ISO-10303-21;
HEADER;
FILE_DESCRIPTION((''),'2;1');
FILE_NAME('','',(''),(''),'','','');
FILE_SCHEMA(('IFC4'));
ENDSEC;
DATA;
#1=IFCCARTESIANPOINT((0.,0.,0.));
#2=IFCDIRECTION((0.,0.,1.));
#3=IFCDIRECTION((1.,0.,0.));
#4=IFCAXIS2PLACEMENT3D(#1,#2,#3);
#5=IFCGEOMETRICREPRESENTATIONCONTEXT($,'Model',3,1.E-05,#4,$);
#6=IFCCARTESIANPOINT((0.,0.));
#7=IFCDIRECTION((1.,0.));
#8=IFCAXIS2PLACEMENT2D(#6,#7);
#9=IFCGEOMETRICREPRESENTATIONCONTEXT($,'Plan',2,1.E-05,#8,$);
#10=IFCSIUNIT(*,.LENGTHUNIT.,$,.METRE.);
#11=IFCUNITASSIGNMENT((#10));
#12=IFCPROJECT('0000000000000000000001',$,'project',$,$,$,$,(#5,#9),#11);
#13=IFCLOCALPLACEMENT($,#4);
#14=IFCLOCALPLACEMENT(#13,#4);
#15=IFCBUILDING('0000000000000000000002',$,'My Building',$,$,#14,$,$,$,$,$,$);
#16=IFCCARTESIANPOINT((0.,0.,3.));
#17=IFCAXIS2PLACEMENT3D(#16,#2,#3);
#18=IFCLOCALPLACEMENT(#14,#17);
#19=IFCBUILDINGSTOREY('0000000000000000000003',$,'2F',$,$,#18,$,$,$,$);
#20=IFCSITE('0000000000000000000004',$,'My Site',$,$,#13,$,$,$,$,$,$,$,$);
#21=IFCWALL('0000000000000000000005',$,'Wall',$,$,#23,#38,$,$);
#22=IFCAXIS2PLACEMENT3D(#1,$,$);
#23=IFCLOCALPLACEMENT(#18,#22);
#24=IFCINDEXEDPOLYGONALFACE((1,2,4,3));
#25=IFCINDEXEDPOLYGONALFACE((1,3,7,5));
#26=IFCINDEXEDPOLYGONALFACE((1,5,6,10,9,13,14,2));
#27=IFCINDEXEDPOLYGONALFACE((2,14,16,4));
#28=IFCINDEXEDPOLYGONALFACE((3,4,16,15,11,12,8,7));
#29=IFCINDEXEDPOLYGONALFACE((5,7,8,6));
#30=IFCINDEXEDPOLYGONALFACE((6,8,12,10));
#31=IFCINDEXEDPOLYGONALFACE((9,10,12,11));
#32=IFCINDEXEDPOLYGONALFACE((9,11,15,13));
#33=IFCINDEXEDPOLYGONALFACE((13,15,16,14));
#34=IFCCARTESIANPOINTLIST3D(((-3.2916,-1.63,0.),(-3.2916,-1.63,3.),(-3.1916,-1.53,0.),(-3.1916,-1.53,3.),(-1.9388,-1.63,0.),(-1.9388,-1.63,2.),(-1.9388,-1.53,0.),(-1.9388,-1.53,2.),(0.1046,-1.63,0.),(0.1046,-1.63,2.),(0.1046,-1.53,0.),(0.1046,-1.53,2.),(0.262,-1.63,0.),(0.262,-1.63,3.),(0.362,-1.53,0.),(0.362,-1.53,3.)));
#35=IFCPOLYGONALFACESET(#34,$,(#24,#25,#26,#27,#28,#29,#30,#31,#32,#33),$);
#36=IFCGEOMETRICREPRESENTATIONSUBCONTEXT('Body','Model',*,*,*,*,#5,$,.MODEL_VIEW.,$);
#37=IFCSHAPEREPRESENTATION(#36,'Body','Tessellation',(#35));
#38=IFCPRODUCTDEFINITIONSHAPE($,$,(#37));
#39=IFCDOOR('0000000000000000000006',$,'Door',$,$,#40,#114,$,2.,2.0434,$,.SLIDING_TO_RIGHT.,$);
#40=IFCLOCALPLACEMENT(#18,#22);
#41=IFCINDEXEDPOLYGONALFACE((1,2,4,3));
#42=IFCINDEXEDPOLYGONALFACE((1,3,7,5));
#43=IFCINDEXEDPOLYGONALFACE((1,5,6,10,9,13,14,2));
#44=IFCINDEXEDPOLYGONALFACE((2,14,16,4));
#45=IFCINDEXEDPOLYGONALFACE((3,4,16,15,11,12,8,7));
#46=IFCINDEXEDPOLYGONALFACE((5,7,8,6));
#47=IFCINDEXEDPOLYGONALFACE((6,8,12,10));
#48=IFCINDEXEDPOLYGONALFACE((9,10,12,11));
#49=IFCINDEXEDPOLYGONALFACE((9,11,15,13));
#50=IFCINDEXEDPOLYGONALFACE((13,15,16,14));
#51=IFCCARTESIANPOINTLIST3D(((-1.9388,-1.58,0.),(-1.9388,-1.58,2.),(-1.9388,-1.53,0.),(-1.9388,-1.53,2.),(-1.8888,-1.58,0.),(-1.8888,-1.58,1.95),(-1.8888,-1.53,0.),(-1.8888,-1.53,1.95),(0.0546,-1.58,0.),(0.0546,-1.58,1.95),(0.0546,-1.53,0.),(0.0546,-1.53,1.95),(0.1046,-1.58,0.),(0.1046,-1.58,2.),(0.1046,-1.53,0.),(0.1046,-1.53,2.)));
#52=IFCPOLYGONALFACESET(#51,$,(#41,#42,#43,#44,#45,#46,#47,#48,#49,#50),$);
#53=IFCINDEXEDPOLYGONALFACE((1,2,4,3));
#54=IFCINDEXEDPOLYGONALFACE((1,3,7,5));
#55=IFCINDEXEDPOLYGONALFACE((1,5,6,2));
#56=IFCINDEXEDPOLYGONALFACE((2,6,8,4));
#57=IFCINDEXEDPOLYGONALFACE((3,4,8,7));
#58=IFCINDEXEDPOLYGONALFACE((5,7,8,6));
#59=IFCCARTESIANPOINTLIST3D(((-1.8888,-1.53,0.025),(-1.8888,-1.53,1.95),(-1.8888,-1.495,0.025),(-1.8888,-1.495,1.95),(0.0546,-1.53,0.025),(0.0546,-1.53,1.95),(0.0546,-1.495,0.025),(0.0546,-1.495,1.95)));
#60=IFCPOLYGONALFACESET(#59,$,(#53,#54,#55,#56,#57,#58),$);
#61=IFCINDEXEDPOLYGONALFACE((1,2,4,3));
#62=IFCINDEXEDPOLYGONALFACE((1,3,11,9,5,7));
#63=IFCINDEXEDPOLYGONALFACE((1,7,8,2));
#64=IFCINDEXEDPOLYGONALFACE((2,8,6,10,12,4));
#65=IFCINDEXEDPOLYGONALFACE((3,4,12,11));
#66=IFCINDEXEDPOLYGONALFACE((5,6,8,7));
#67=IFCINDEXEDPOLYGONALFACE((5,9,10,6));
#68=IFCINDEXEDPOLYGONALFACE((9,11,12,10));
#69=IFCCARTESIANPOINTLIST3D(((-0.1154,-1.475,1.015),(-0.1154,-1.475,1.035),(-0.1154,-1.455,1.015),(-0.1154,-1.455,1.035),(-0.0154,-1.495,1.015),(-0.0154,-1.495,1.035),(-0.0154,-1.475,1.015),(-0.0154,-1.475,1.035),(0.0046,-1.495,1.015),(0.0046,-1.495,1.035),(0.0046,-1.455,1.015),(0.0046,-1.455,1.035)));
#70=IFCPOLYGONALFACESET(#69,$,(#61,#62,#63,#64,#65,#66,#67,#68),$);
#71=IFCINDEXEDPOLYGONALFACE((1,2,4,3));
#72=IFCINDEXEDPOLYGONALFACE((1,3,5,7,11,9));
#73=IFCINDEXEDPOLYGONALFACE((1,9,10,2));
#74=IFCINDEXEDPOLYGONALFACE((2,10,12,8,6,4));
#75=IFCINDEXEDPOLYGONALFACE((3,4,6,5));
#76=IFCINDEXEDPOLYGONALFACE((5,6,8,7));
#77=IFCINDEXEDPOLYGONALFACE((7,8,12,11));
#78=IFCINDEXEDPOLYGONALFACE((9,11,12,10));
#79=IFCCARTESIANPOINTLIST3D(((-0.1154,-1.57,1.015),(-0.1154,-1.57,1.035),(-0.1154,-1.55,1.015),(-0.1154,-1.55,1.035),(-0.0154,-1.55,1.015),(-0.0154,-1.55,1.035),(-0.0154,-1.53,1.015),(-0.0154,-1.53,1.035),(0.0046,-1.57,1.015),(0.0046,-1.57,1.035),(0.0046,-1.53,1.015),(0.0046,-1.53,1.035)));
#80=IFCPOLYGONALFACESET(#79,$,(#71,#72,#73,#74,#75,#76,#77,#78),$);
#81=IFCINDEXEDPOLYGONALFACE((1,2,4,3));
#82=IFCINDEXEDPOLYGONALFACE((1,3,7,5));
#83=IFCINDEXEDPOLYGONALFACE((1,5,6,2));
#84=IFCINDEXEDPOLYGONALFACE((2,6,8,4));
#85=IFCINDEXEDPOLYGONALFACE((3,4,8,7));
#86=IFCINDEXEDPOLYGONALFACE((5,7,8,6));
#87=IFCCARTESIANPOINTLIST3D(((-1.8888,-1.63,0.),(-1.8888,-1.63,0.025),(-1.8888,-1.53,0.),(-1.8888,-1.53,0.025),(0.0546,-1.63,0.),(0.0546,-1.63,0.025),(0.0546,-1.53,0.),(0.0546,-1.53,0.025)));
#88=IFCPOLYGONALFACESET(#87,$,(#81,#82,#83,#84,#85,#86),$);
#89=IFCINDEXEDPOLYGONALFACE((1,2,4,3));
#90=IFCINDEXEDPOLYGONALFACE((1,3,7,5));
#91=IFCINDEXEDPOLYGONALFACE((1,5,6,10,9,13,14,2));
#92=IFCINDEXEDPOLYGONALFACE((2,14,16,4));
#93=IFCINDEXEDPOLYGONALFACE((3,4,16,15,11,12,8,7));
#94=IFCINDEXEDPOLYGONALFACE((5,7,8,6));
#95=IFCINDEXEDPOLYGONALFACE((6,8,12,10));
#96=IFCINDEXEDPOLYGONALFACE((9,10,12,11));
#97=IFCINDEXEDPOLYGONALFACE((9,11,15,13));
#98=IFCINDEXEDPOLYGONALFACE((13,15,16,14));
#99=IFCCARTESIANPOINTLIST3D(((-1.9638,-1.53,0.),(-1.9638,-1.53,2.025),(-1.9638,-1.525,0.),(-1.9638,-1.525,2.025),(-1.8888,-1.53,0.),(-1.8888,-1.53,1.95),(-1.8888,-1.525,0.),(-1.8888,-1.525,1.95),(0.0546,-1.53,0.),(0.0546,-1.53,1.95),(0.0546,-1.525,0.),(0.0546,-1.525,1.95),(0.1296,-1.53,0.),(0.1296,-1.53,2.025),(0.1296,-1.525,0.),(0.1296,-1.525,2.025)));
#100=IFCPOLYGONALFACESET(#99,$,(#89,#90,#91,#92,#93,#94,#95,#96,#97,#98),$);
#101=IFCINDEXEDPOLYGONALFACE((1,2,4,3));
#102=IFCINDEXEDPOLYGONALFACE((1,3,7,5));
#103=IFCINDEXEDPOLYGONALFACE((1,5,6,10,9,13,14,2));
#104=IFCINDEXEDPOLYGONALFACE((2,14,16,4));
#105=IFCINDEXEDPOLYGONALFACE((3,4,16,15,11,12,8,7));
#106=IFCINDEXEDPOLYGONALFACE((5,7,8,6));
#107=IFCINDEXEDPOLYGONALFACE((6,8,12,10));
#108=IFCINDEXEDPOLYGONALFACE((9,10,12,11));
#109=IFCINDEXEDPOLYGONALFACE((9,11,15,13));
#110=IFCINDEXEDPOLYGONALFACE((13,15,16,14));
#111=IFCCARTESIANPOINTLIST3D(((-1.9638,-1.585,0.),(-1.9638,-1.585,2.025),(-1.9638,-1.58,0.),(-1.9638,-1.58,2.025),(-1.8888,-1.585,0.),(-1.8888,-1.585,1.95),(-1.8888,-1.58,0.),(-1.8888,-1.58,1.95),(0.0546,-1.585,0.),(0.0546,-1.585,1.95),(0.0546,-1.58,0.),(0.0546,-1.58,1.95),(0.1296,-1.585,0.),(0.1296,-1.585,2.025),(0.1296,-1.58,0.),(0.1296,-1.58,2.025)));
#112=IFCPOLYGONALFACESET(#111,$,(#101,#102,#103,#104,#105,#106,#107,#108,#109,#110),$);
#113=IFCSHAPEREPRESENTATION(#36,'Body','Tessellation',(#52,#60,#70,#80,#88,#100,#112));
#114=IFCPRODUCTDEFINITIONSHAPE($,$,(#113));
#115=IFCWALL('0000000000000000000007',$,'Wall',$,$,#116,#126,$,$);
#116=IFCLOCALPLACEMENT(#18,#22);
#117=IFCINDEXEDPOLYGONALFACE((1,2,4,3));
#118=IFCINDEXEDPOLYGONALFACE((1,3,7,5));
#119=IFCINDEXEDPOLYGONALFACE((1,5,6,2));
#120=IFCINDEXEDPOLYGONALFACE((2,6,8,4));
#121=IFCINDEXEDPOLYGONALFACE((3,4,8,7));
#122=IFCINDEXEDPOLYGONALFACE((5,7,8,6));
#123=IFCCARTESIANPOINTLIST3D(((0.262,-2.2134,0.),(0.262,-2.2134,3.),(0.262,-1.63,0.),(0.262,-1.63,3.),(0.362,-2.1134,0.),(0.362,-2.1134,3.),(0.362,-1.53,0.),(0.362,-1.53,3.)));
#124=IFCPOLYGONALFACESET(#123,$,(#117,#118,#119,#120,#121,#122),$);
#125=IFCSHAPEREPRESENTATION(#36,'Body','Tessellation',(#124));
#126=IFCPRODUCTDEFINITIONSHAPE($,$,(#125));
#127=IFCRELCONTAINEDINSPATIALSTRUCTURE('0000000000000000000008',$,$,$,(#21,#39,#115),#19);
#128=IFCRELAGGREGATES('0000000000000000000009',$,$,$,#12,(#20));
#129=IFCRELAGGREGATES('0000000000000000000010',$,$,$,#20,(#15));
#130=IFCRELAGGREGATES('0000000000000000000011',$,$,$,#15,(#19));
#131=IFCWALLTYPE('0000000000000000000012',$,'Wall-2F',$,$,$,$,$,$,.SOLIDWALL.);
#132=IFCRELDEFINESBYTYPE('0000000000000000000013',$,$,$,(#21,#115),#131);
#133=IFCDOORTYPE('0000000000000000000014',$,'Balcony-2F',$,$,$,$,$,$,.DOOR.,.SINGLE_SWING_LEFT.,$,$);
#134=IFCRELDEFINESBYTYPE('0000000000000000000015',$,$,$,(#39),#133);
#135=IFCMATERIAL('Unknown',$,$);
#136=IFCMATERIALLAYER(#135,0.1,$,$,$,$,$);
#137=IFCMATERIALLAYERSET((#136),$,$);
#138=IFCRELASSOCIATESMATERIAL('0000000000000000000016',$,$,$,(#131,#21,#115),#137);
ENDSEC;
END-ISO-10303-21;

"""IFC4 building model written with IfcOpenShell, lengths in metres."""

from ifc_helpers import new_model, entity, si_unit, frame, origin_with_axes, origin_2d_with_axis, place, context, subcontext, project, spatial, line, indexed_curve, outline, extrude, shape, source, transform, mapped, material, layer, layer_set, layer_usage, type_object, type_shapes, element, fill, save


model = new_model("IFC4")

# Units and contexts
model_context = context("Model", 3, precision=1e-05, world=origin_with_axes())
plan_context = context("Plan", 2, precision=1e-05, world=origin_2d_with_axis())
body_context_1 = subcontext(model_context, "Body", "Model", "MODEL_VIEW")
body_context_2 = subcontext(plan_context, "Body", "Plan", "PLAN_VIEW")
ifc_project = project(units=[si_unit("LENGTHUNIT", "METRE")], contexts=[model_context, plan_context])

# Site, building, storey
site_placement = place(None, origin_with_axes())
site = spatial("IfcSite", under=ifc_project, at=site_placement, Name="My Site")
building_placement = place(site_placement, origin_with_axes())
building = spatial("IfcBuilding", under=site, at=building_placement, Name="My Building")
storey_placement = place(building_placement, frame((0.0, 0.0, 3.0), z_axis=(0.0, 0.0, 1.0), x_axis=(1.0, 0.0, 0.0)))
storey = spatial("IfcBuildingStorey", under=building, at=storey_placement, Name="2F")

# Shared definitions
ifc_material = material(Name="Unknown")

# Wall, opening, door
ifc_layer_1 = layer(ifc_material, 0.1)
ifc_layer_set_1 = layer_set([ifc_layer_1])
ifc_layer_usage_1 = layer_usage(ifc_layer_set_1, "AXIS2", "POSITIVE", 0.0)
wall_type_1 = type_object("IfcWallType", Name="Wall-2F", PredefinedType="SOLIDWALL", material=ifc_layer_set_1)
wall_1_placement = place(storey_placement, frame((-3.2916, -1.63, 0.0), z_axis=(0.0, 0.0, 1.0), x_axis=(1.0, 0.0, 0.0)))
wall_1 = element("IfcWall", 1, at=wall_1_placement, inside=storey, type_object=wall_type_1, material=ifc_layer_usage_1, Name="Wall", context=body_context_1, shape_type="SweptSolid", body=[
    extrude(outline(indexed_curve([(0.0, 0.0), (0.1, 0.1), (3.6537, 0.1), (3.5537, 0.0)], segments=[line(1, 2, 3, 4, 1)])), origin_with_axes(), (0.0, 0.0, 1.0), 3.0),
])
shared_shape_1 = source(origin_with_axes(), body_context_1, "Body", "SweptSolid", [
    extrude(outline(indexed_curve([(0.0, 0.0), (2.0434, 0.0), (2.0434, 2.0), (0.0, 2.0)], segments=[line(1, 2, 3, 4, 1)])), frame((0.0, -0.6, 0.0), z_axis=(0.0, -1.0, 0.0), x_axis=(1.0, 0.0, 0.0)), (0.0, 0.0, -1.0), 1.2),
])
opening_1_placement = place(wall_1_placement, frame((3.3963, 0.1, 0.0), z_axis=(0.0, 0.0, 1.0), x_axis=(-1.0, 0.0, 0.0)))
opening_1 = element("IfcOpeningElement", 2, at=opening_1_placement, cuts=wall_1, PredefinedType="OPENING", context=body_context_1, shape_type="MappedRepresentation", body=[
    mapped(shared_shape_1, transform((0.0, 0.0, 0.0), x_axis=(1.0, 0.0, 0.0), y_axis=(0.0, 1.0, 0.0), z_axis=(0.0, 0.0, 1.0), scale=1.0)),
])
door_type_1 = type_object("IfcDoorType", Name="Balcony-2F", OperationType="SINGLE_SWING_LEFT", PredefinedType="DOOR")
shared_shape_2 = source(origin_with_axes(), body_context_1, "Body", "SweptSolid", [
    extrude(outline(indexed_curve([(0.0, 0.0), (0.0, 2.0), (2.0434, 2.0), (2.0434, 0.0), (1.9934, 0.0), (1.9934, 1.95), (0.05, 1.95), (0.05, 0.0)], segments=[line(1, 2, 3, 4, 5, 6, 7, 8, 1)])), frame((0.0, 0.0, 0.0), z_axis=(0.0, -1.0, 0.0), x_axis=(1.0, 0.0, 0.0)), (0.0, 0.0, -1.0), 0.05),
    extrude(outline(indexed_curve([(0.0, 0.0), (1.9434, 0.0), (1.9434, 0.035), (0.0, 0.035)], segments=[line(1, 2, 3, 4, 1)])), frame((0.05, -0.035, 0.025), z_axis=(0.0, 0.0, 1.0), x_axis=(1.0, 0.0, 0.0)), (0.0, 0.0, 1.0), 1.925),
    extrude(outline(indexed_curve([(0.0, 0.0), (0.0, -0.04), (0.12, -0.04), (0.12, -0.02), (0.02, -0.02), (0.02, 0.0)], segments=[line(1, 2, 3, 4, 5, 6, 1)])), frame((0.1, -0.035, 1.015), z_axis=(0.0, 0.0, 1.0), x_axis=(1.0, 0.0, 0.0)), (0.0, 0.0, 1.0), 0.02),
    extrude(outline(indexed_curve([(0.0, 0.0), (0.0, 0.04), (0.12, 0.04), (0.12, 0.02), (0.02, 0.02), (0.02, 0.0)], segments=[line(1, 2, 3, 4, 5, 6, 1)])), frame((0.1, 0.0, 1.015), z_axis=(0.0, 0.0, 1.0), x_axis=(1.0, 0.0, 0.0)), (0.0, 0.0, 1.0), 0.02),
    extrude(outline(indexed_curve([(0.0, 0.0), (1.9434, 0.0), (1.9434, 0.1), (0.0, 0.1)], segments=[line(1, 2, 3, 4, 1)])), frame((0.05, 0.0, 0.0), z_axis=(0.0, 0.0, 1.0), x_axis=(1.0, 0.0, 0.0)), (0.0, 0.0, 1.0), 0.025),
    extrude(outline(indexed_curve([(0.0, 0.0), (0.0, 2.025), (2.0934, 2.025), (2.0934, 0.0), (2.0184, 0.0), (2.0184, 1.95), (0.075, 1.95), (0.075, 0.0)], segments=[line(1, 2, 3, 4, 5, 6, 7, 8, 1)])), frame((-0.025, -0.005, 0.0), z_axis=(0.0, -1.0, 0.0), x_axis=(1.0, 0.0, 0.0)), (0.0, 0.0, -1.0), 0.005),
    extrude(outline(indexed_curve([(0.0, 0.0), (0.0, 2.025), (2.0934, 2.025), (2.0934, 0.0), (2.0184, 0.0), (2.0184, 1.95), (0.075, 1.95), (0.075, 0.0)], segments=[line(1, 2, 3, 4, 5, 6, 7, 8, 1)])), frame((-0.025, 0.05, 0.0), z_axis=(0.0, -1.0, 0.0), x_axis=(1.0, 0.0, 0.0)), (0.0, 0.0, -1.0), 0.005),
])
shared_shape_3 = source(origin_with_axes(), body_context_2, "Body", "Curve2D", [
    entity("IfcIndexedPolyCurve", entity("IfcCartesianPointList2D", [[0.0, 0.0], [0.05, 0.0], [0.05, 0.05], [0.0, 0.05]]), [entity("IfcLineIndex", [1, 2, 3, 4, 1])]),
    entity("IfcIndexedPolyCurve", entity("IfcCartesianPointList2D", [[2.0434, 0.0], [1.9934, 0.0], [1.9934, 0.05], [2.0434, 0.05]]), [entity("IfcLineIndex", [1, 2, 3, 4, 1])]),
    entity("IfcIndexedPolyCurve", entity("IfcCartesianPointList2D", [[2.965, -0.035], [1.0217, -0.035], [1.0217, 0.0], [2.965, 0.0]]), [entity("IfcLineIndex", [1, 2, 3, 4, 1])]),
])
type_shapes(door_type_1, [shared_shape_2, shared_shape_3])
door_1_placement = place(opening_1_placement, frame((0.0, 0.0, 0.0), z_axis=(0.0, 0.0, 1.0), x_axis=(1.0, 0.0, 0.0)))
door_1 = element("IfcDoor", 3, at=door_1_placement, inside=storey, type_object=door_type_1, Name="Door", OperationType="SLIDING_TO_RIGHT", OverallHeight=2.0, OverallWidth=2.0434, shapes=[
    shape(body_context_1, "Body", "MappedRepresentation", [mapped(shared_shape_2, transform((0.0, 0.0, 0.0), x_axis=(1.0, 0.0, 0.0), y_axis=(0.0, 1.0, 0.0), z_axis=(0.0, 0.0, 1.0), scale=1.0))]),
    shape(body_context_2, "Body", "MappedRepresentation", [mapped(shared_shape_3, transform((0.0, 0.0, 0.0), x_axis=(1.0, 0.0, 0.0), y_axis=(0.0, 1.0, 0.0), z_axis=(0.0, 0.0, 1.0), scale=1.0))]),
])
fill(opening_1, door_1)

# Wall
ifc_layer_usage_2 = layer_usage(ifc_layer_set_1, "AXIS2", "POSITIVE", 0.0)
wall_2_placement = place(storey_placement, frame((0.262, -1.63, 0.0), z_axis=(0.0, 0.0, 1.0), x_axis=(0.000001, -1.0, 0.0)))
element("IfcWall", 4, at=wall_2_placement, inside=storey, type_object=wall_type_1, material=ifc_layer_usage_2, Name="Wall", context=body_context_1, shape_type="SweptSolid", body=[
    extrude(outline(indexed_curve([(0.0, 0.0), (-0.1, 0.1), (0.4834, 0.1), (0.5834, 0.0)], segments=[line(1, 2, 3, 4, 1)])), origin_with_axes(), (0.0, 0.0, 1.0), 3.0),
])

save(model, "model.ifc")
